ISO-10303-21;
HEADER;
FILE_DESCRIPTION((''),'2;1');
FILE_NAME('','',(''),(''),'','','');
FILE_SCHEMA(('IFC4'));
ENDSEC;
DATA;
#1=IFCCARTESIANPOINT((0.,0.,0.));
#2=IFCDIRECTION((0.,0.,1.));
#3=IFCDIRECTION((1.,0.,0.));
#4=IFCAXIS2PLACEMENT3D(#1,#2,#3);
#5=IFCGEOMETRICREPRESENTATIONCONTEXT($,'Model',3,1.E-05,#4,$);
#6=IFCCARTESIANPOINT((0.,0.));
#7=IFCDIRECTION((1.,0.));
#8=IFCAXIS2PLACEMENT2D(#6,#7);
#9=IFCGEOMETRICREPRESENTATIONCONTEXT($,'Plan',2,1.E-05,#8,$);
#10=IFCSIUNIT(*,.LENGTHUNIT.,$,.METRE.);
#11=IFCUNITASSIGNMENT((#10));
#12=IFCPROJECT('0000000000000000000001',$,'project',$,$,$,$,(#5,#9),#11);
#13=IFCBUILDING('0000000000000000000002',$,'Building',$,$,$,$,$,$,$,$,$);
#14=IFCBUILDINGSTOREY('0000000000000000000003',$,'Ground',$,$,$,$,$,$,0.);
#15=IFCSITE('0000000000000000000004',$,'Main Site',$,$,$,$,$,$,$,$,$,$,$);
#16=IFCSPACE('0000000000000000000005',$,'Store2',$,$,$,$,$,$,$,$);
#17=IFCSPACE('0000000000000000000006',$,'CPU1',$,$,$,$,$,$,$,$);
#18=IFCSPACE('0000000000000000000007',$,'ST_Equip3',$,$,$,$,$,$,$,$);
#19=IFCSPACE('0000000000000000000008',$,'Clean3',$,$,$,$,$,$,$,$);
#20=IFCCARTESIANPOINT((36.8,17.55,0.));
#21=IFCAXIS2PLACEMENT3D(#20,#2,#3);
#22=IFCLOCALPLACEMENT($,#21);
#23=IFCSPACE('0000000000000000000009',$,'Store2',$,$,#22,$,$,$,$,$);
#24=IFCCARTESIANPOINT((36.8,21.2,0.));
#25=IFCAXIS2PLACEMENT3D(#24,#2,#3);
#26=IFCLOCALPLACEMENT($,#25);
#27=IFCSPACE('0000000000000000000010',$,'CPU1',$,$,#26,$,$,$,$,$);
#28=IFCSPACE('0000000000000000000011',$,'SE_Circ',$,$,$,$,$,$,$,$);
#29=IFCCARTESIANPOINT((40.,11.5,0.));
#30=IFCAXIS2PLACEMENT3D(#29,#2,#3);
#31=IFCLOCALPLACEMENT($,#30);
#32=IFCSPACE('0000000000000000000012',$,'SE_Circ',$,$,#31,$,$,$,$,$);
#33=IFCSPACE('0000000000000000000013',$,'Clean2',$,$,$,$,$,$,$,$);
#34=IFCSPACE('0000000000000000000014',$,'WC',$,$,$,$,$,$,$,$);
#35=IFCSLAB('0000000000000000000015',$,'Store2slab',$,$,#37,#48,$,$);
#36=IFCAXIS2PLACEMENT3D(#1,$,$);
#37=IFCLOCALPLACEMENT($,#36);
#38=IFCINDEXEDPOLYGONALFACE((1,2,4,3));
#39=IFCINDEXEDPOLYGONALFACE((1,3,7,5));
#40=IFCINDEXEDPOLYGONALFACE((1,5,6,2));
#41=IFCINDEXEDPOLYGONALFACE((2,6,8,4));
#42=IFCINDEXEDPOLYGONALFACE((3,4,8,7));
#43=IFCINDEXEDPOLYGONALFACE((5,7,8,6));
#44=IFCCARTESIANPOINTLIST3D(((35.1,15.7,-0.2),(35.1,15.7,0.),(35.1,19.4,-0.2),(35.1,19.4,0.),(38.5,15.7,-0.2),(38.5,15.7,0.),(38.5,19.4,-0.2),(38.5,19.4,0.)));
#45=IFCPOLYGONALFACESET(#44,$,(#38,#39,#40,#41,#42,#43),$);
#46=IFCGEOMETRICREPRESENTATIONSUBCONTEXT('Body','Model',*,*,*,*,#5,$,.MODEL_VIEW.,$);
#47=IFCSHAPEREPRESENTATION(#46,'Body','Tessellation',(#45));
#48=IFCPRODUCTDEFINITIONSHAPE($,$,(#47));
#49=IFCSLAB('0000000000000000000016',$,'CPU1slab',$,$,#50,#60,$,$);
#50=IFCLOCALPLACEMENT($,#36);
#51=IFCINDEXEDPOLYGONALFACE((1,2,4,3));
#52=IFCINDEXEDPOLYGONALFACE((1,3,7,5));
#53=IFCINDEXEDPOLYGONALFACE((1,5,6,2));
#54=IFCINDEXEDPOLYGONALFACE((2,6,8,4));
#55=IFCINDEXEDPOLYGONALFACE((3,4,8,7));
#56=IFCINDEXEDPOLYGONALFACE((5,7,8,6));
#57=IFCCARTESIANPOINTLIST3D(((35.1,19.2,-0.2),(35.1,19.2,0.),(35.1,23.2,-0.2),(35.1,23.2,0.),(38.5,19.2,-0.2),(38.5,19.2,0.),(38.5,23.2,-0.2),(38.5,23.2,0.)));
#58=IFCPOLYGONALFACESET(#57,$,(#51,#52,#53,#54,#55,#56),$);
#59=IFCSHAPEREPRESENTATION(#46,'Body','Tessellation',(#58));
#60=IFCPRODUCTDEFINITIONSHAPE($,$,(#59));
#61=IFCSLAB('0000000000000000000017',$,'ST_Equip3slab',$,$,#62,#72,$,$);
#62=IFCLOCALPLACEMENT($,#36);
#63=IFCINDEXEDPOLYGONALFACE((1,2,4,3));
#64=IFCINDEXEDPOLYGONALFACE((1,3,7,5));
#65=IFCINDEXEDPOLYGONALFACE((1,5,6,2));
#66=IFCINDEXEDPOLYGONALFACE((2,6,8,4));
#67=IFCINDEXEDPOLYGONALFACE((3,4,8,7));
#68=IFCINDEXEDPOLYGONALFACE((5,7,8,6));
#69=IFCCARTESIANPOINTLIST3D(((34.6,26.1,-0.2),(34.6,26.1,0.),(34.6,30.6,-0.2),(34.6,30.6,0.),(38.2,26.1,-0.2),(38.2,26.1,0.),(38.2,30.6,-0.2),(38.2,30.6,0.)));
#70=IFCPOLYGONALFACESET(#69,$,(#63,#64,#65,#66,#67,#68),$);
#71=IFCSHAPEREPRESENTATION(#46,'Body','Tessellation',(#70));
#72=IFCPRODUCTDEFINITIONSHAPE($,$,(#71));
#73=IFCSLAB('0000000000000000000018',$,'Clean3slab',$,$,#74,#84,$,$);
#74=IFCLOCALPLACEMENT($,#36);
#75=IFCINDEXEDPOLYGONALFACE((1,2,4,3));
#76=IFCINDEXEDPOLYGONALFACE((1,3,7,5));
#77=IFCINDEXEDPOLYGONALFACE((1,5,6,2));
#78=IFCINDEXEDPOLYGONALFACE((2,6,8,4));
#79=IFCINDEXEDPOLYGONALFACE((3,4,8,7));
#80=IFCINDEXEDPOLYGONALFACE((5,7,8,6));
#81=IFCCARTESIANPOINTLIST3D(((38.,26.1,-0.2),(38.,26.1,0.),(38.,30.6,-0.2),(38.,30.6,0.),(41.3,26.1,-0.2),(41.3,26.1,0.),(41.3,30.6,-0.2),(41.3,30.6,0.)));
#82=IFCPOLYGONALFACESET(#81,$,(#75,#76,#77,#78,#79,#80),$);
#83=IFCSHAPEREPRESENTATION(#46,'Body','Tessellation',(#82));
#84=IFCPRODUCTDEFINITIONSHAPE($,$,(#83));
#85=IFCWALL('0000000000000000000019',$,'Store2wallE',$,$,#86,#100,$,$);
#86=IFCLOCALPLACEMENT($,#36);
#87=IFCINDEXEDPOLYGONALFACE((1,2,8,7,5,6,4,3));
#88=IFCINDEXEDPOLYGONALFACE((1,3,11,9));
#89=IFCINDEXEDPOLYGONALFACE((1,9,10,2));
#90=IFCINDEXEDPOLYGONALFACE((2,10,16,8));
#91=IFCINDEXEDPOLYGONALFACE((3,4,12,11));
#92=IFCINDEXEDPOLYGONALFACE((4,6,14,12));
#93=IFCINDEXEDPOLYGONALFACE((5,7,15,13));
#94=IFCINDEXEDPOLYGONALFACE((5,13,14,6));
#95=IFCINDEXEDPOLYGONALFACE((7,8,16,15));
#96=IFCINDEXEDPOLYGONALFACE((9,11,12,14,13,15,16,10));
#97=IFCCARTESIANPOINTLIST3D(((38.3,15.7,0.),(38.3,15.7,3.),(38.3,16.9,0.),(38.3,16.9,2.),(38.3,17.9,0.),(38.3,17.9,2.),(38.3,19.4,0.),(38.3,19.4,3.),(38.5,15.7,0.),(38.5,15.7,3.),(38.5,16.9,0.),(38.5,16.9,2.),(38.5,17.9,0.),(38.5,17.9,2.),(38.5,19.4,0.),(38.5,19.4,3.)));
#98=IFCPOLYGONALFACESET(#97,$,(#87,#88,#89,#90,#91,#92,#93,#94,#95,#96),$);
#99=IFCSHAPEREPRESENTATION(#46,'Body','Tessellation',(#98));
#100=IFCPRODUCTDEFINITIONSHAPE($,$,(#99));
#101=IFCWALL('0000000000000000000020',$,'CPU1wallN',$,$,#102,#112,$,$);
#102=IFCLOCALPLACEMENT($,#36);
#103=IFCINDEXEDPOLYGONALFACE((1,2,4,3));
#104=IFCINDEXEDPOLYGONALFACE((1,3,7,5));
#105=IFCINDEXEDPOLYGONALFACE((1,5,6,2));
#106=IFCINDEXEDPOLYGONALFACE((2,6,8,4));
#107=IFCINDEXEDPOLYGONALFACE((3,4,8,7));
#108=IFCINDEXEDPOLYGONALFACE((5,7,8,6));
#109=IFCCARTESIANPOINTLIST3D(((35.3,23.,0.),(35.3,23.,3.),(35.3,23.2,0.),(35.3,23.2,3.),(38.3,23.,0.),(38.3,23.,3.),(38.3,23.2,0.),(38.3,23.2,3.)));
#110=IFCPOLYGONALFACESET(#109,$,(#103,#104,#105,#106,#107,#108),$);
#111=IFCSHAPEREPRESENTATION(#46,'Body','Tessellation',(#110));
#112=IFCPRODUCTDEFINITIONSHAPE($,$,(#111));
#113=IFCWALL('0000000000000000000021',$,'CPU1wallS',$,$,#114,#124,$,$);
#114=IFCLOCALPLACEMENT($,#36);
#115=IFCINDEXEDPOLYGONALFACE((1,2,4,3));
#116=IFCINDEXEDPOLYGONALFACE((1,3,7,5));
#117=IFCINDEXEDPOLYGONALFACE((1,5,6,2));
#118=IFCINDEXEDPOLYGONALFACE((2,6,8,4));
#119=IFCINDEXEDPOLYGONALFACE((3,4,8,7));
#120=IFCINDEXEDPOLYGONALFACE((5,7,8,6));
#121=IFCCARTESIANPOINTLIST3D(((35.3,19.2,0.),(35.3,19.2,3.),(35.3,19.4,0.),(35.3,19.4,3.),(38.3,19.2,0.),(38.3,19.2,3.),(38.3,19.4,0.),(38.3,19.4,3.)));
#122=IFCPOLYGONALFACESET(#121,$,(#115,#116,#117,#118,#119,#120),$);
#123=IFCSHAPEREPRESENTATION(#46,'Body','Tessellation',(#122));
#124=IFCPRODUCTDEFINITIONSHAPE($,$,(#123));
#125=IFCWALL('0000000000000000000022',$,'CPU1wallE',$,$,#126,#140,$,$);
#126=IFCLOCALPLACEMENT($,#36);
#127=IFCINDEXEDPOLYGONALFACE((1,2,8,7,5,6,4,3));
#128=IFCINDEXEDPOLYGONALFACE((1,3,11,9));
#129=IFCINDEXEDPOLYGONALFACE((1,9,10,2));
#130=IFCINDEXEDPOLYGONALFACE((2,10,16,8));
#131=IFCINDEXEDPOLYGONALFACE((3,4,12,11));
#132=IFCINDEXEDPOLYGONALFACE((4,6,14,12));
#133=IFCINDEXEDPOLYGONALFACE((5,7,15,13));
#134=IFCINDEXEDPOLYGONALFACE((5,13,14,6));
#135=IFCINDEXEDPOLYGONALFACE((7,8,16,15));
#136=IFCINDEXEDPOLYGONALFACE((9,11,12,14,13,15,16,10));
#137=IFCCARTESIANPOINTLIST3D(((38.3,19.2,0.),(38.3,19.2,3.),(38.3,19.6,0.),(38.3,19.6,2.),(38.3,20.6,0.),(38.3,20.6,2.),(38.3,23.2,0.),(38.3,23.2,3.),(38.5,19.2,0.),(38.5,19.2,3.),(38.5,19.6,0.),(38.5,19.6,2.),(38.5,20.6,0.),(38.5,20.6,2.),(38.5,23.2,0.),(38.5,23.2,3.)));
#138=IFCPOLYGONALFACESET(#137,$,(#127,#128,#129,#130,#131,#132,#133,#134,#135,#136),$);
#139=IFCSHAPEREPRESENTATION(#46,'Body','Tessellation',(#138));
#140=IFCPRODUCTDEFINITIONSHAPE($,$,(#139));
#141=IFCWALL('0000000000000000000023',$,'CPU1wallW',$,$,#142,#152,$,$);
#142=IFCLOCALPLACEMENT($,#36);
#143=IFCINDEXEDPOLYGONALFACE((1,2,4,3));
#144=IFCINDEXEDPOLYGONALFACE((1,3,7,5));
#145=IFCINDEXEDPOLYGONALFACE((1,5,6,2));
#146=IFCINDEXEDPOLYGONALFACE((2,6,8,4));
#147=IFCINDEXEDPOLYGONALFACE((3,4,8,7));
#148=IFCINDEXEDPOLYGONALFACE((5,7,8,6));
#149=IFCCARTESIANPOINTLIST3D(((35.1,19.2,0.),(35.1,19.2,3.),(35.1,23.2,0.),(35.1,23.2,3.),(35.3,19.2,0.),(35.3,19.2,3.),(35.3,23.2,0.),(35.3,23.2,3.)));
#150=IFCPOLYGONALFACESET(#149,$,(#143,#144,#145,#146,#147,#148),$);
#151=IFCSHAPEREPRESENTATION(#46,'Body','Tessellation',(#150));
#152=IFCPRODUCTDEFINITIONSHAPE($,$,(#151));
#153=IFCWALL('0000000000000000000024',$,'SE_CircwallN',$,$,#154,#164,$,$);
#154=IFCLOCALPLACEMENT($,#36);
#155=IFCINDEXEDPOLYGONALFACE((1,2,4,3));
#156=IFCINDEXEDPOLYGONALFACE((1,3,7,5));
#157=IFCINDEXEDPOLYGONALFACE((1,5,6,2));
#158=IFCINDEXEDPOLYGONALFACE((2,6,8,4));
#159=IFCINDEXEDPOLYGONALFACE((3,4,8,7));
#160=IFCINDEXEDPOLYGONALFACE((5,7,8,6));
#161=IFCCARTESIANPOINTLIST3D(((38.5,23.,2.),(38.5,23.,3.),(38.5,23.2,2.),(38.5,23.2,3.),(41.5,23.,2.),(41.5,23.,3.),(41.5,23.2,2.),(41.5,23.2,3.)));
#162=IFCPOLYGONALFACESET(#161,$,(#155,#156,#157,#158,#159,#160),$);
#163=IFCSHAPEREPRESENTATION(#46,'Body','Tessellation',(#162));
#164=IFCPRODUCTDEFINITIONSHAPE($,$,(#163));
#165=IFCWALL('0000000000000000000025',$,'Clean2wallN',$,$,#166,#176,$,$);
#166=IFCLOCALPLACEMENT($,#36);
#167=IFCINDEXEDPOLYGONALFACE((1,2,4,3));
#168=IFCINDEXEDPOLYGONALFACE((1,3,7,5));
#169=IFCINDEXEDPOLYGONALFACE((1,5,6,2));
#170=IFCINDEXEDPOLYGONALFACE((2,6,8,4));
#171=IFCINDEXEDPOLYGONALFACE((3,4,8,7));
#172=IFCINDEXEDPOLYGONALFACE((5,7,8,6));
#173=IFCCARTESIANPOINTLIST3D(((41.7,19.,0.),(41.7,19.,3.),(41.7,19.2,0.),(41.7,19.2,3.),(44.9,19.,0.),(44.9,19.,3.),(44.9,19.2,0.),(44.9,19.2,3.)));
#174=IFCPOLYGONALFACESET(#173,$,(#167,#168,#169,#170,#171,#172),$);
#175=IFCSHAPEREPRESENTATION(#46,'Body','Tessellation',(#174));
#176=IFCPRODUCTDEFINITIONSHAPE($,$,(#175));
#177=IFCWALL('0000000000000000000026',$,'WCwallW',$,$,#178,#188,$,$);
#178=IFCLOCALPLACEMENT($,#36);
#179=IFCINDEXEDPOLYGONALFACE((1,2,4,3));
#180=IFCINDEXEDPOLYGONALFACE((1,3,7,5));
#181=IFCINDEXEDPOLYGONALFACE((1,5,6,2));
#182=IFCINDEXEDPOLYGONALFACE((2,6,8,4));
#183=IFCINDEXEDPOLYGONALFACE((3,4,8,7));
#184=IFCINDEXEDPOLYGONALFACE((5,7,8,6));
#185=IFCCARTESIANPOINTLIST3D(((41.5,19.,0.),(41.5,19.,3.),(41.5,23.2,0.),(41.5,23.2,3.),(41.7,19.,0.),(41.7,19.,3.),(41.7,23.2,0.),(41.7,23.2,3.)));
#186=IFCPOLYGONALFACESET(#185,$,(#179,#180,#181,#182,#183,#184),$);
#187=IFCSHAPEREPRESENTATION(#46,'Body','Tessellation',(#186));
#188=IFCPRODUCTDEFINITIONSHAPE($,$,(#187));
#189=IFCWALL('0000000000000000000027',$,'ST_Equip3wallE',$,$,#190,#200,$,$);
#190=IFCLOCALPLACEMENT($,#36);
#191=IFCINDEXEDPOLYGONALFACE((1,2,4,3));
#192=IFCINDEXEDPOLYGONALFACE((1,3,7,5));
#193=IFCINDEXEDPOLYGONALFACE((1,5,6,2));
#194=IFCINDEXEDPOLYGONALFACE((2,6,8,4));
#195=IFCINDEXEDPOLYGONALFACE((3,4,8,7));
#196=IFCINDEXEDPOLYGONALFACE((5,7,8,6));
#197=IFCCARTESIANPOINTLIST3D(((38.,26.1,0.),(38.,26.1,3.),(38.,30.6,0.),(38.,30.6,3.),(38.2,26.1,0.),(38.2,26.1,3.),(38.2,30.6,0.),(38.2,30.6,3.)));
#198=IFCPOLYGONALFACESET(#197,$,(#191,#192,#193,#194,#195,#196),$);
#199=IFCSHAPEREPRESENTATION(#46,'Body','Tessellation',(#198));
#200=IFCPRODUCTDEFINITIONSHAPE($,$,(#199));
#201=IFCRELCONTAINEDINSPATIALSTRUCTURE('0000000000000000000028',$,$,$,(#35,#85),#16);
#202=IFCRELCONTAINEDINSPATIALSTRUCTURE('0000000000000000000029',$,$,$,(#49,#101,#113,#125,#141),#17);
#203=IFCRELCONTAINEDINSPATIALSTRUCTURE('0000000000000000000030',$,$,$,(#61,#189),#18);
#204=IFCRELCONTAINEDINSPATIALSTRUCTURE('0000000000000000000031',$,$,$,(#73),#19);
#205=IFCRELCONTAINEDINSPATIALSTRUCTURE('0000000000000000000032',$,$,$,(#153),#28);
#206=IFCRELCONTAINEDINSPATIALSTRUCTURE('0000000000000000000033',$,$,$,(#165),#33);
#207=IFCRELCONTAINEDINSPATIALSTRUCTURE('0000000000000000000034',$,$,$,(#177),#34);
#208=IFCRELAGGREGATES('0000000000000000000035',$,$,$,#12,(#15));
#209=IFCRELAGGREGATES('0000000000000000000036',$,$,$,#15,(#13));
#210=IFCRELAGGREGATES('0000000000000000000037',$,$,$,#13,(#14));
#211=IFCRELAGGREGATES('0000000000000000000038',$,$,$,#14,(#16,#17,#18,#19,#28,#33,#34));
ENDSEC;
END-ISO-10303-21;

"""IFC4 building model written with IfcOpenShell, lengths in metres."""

from ifc_helpers import new_model, si_unit, frame, origin_with_axes, origin_2d_with_axis, place, context, subcontext, project, spatial, indexed_curve, rectangle, outline, extrude, element, save


model = new_model("IFC4")

# Units and contexts
model_context = context("Model", 3, precision=1e-05, world=origin_with_axes())
plan_context = context("Plan", 2, precision=1e-05, world=origin_2d_with_axis())
body_context = subcontext(model_context, "Body", "Model", "MODEL_VIEW")
ifc_project = project(units=[si_unit("LENGTHUNIT", "METRE")], contexts=[model_context, plan_context])

# Site, building, storey, space
site = spatial("IfcSite", under=ifc_project, Name="Main Site")
building = spatial("IfcBuilding", under=site, Name="Building")
storey = spatial("IfcBuildingStorey", under=building, Name="Ground", Elevation=0.0)
space_1 = spatial("IfcSpace", under=storey, Name="Store2")

# Slab
slab_1_placement = place(None, frame((36.8, 17.55, -0.2), z_axis=(0.0, 0.0, 1.0), x_axis=(1.0, 0.0, 0.0)))
element("IfcSlab", 1, at=slab_1_placement, inside=space_1, Name="Store2slab", context=body_context, shape_type="SweptSolid", body=[
    extrude(rectangle(XDim=3.4, YDim=3.7), origin_with_axes(), (0.0, 0.0, 1.0), 0.2),
])

# Shared definitions
space_2 = spatial("IfcSpace", under=storey, Name="CPU1")

# Slab
slab_2_placement = place(None, frame((36.8, 21.2, -0.2), z_axis=(0.0, 0.0, 1.0), x_axis=(1.0, 0.0, 0.0)))
element("IfcSlab", 2, at=slab_2_placement, inside=space_2, Name="CPU1slab", context=body_context, shape_type="SweptSolid", body=[
    extrude(rectangle(XDim=3.4, YDim=4.0), origin_with_axes(), (0.0, 0.0, 1.0), 0.2),
])

# Shared definitions
space_3 = spatial("IfcSpace", under=storey, Name="ST_Equip3")

# Slab
slab_3_placement = place(None, frame((36.4, 28.35, -0.2), z_axis=(0.0, 0.0, 1.0), x_axis=(1.0, 0.0, 0.0)))
element("IfcSlab", 3, at=slab_3_placement, inside=space_3, Name="ST_Equip3slab", context=body_context, shape_type="SweptSolid", body=[
    extrude(rectangle(XDim=3.6, YDim=4.5), origin_with_axes(), (0.0, 0.0, 1.0), 0.2),
])

# Shared definitions
space_4 = spatial("IfcSpace", under=storey, Name="Clean3")

# Slab
slab_4_placement = place(None, frame((39.65, 28.35, -0.2), z_axis=(0.0, 0.0, 1.0), x_axis=(1.0, 0.0, 0.0)))
element("IfcSlab", 4, at=slab_4_placement, inside=space_4, Name="Clean3slab", context=body_context, shape_type="SweptSolid", body=[
    extrude(rectangle(XDim=3.3, YDim=4.5), origin_with_axes(), (0.0, 0.0, 1.0), 0.2),
])

# Wall
wall_1_placement = place(None, frame((38.5, 15.7, 0.0), z_axis=(0.0, 0.0, 1.0), x_axis=(0.0, 1.0, 0.0)))
wall_1 = element("IfcWall", 5, at=wall_1_placement, inside=space_1, Name="Store2wallE", context=body_context, shape_type="SweptSolid", body=[
    extrude(outline(indexed_curve([(0.0, 0.0), (0.0, 0.2), (3.7, 0.2), (3.7, 0.0), (0.0, 0.0)], self_intersect=False)), origin_with_axes(), (0.0, 0.0, 1.0), 3.0),
])

# Shared definitions
space_5_placement = place(None, frame((36.8, 17.55, 0.0), z_axis=(0.0, 0.0, 1.0), x_axis=(1.0, 0.0, 0.0)))
space_5 = spatial("IfcSpace", at=space_5_placement, Name="Store2")

# Opening
opening_1_placement = place(wall_1_placement, frame((1.2, 0.0, 0.0), z_axis=(0.0, 0.0, 1.0), x_axis=(1.0, 0.0, 0.0)))
element("IfcOpeningElement", 6, at=opening_1_placement, inside=space_5, cuts=wall_1, context=body_context, shape_type="SweptSolid", body=[
    extrude(outline(indexed_curve([(0.0, 0.0), (0.0, 0.4), (1.0, 0.4), (1.0, 0.0), (0.0, 0.0)], self_intersect=False)), origin_with_axes(), (0.0, 0.0, 1.0), 2.0),
])

# Walls
for number, where, z_axis, x_axis, name in (
    (7, (35.3, 23.0, 0.0), (0.0, 0.0, 1.0), (1.0, 0.0, 0.0), "CPU1wallN"),
    (8, (35.3, 19.2, 0.0), (0.0, 0.0, 1.0), (1.0, 0.0, 0.0), "CPU1wallS"),
):
    element("IfcWall", number, at=place(None, frame(where, z_axis=z_axis, x_axis=x_axis)), inside=space_2, Name=name, context=body_context, shape_type="SweptSolid", body=[
        extrude(outline(indexed_curve([(0.0, 0.0), (0.0, 0.2), (3.0, 0.2), (3.0, 0.0), (0.0, 0.0)], self_intersect=False)), origin_with_axes(), (0.0, 0.0, 1.0), 3.0),
    ])

# Wall
wall_2_placement = place(None, frame((38.5, 19.2, 0.0), z_axis=(0.0, 0.0, 1.0), x_axis=(0.0, 1.0, 0.0)))
wall_2 = element("IfcWall", 9, at=wall_2_placement, inside=space_2, Name="CPU1wallE", context=body_context, shape_type="SweptSolid", body=[
    extrude(outline(indexed_curve([(0.0, 0.0), (0.0, 0.2), (4.0, 0.2), (4.0, 0.0), (0.0, 0.0)], self_intersect=False)), origin_with_axes(), (0.0, 0.0, 1.0), 3.0),
])

# Shared definitions
space_6_placement = place(None, frame((36.8, 21.2, 0.0), z_axis=(0.0, 0.0, 1.0), x_axis=(1.0, 0.0, 0.0)))
space_6 = spatial("IfcSpace", at=space_6_placement, Name="CPU1")

# Opening
opening_2_placement = place(wall_2_placement, frame((0.4, 0.0, 0.0), z_axis=(0.0, 0.0, 1.0), x_axis=(1.0, 0.0, 0.0)))
element("IfcOpeningElement", 10, at=opening_2_placement, inside=space_6, cuts=wall_2, context=body_context, shape_type="SweptSolid", body=[
    extrude(outline(indexed_curve([(0.0, 0.0), (0.0, 0.4), (1.0, 0.4), (1.0, 0.0), (0.0, 0.0)], self_intersect=False)), origin_with_axes(), (0.0, 0.0, 1.0), 2.0),
])

# Wall
wall_3_placement = place(None, frame((35.3, 19.2, 0.0), z_axis=(0.0, 0.0, 1.0), x_axis=(0.0, 1.0, 0.0)))
element("IfcWall", 11, at=wall_3_placement, inside=space_2, Name="CPU1wallW", context=body_context, shape_type="SweptSolid", body=[
    extrude(outline(indexed_curve([(0.0, 0.0), (0.0, 0.2), (4.0, 0.2), (4.0, 0.0), (0.0, 0.0)], self_intersect=False)), origin_with_axes(), (0.0, 0.0, 1.0), 3.0),
])

# Shared definitions
space_7 = spatial("IfcSpace", under=storey, Name="SE_Circ")

# Wall
wall_4_placement = place(None, frame((38.5, 23.0, 0.0), z_axis=(0.0, 0.0, 1.0), x_axis=(1.0, 0.0, 0.0)))
wall_4 = element("IfcWall", 12, at=wall_4_placement, inside=space_7, Name="SE_CircwallN", context=body_context, shape_type="SweptSolid", body=[
    extrude(outline(indexed_curve([(0.0, 0.0), (0.0, 0.2), (3.0, 0.2), (3.0, 0.0), (0.0, 0.0)], self_intersect=False)), origin_with_axes(), (0.0, 0.0, 1.0), 3.0),
])

# Shared definitions
space_8_placement = place(None, frame((40.0, 11.5, 0.0), z_axis=(0.0, 0.0, 1.0), x_axis=(1.0, 0.0, 0.0)))
space_8 = spatial("IfcSpace", at=space_8_placement, Name="SE_Circ")

# Opening
opening_3_placement = place(wall_4_placement, origin_with_axes())
element("IfcOpeningElement", 13, at=opening_3_placement, inside=space_8, cuts=wall_4, context=body_context, shape_type="SweptSolid", body=[
    extrude(outline(indexed_curve([(0.0, 0.0), (0.0, 0.4), (3.0, 0.4), (3.0, 0.0), (0.0, 0.0)], self_intersect=False)), origin_with_axes(), (0.0, 0.0, 1.0), 2.0),
])

# Shared definitions
space_9 = spatial("IfcSpace", under=storey, Name="Clean2")

# Wall
wall_5_placement = place(None, frame((41.7, 19.0, 0.0), z_axis=(0.0, 0.0, 1.0), x_axis=(1.0, 0.0, 0.0)))
element("IfcWall", 14, at=wall_5_placement, inside=space_9, Name="Clean2wallN", context=body_context, shape_type="SweptSolid", body=[
    extrude(outline(indexed_curve([(0.0, 0.0), (0.0, 0.2), (3.2, 0.2), (3.2, 0.0), (0.0, 0.0)], self_intersect=False)), origin_with_axes(), (0.0, 0.0, 1.0), 3.0),
])

# Shared definitions
space_10 = spatial("IfcSpace", under=storey, Name="WC")

# Walls
wall_6_placement = place(None, frame((41.7, 19.0, 0.0), z_axis=(0.0, 0.0, 1.0), x_axis=(0.0, 1.0, 0.0)))
element("IfcWall", 15, at=wall_6_placement, inside=space_10, Name="WCwallW", context=body_context, shape_type="SweptSolid", body=[
    extrude(outline(indexed_curve([(0.0, 0.0), (0.0, 0.2), (4.2, 0.2), (4.2, 0.0), (0.0, 0.0)], self_intersect=False)), origin_with_axes(), (0.0, 0.0, 1.0), 3.0),
])
wall_7_placement = place(None, frame((38.2, 26.1, 0.0), z_axis=(0.0, 0.0, 1.0), x_axis=(0.0, 1.0, 0.0)))
element("IfcWall", 16, at=wall_7_placement, inside=space_3, Name="ST_Equip3wallE", context=body_context, shape_type="SweptSolid", body=[
    extrude(outline(indexed_curve([(0.0, 0.0), (0.0, 0.2), (4.5, 0.2), (4.5, 0.0), (0.0, 0.0)], self_intersect=False)), origin_with_axes(), (0.0, 0.0, 1.0), 3.0),
])

save(model, "model.ifc")
